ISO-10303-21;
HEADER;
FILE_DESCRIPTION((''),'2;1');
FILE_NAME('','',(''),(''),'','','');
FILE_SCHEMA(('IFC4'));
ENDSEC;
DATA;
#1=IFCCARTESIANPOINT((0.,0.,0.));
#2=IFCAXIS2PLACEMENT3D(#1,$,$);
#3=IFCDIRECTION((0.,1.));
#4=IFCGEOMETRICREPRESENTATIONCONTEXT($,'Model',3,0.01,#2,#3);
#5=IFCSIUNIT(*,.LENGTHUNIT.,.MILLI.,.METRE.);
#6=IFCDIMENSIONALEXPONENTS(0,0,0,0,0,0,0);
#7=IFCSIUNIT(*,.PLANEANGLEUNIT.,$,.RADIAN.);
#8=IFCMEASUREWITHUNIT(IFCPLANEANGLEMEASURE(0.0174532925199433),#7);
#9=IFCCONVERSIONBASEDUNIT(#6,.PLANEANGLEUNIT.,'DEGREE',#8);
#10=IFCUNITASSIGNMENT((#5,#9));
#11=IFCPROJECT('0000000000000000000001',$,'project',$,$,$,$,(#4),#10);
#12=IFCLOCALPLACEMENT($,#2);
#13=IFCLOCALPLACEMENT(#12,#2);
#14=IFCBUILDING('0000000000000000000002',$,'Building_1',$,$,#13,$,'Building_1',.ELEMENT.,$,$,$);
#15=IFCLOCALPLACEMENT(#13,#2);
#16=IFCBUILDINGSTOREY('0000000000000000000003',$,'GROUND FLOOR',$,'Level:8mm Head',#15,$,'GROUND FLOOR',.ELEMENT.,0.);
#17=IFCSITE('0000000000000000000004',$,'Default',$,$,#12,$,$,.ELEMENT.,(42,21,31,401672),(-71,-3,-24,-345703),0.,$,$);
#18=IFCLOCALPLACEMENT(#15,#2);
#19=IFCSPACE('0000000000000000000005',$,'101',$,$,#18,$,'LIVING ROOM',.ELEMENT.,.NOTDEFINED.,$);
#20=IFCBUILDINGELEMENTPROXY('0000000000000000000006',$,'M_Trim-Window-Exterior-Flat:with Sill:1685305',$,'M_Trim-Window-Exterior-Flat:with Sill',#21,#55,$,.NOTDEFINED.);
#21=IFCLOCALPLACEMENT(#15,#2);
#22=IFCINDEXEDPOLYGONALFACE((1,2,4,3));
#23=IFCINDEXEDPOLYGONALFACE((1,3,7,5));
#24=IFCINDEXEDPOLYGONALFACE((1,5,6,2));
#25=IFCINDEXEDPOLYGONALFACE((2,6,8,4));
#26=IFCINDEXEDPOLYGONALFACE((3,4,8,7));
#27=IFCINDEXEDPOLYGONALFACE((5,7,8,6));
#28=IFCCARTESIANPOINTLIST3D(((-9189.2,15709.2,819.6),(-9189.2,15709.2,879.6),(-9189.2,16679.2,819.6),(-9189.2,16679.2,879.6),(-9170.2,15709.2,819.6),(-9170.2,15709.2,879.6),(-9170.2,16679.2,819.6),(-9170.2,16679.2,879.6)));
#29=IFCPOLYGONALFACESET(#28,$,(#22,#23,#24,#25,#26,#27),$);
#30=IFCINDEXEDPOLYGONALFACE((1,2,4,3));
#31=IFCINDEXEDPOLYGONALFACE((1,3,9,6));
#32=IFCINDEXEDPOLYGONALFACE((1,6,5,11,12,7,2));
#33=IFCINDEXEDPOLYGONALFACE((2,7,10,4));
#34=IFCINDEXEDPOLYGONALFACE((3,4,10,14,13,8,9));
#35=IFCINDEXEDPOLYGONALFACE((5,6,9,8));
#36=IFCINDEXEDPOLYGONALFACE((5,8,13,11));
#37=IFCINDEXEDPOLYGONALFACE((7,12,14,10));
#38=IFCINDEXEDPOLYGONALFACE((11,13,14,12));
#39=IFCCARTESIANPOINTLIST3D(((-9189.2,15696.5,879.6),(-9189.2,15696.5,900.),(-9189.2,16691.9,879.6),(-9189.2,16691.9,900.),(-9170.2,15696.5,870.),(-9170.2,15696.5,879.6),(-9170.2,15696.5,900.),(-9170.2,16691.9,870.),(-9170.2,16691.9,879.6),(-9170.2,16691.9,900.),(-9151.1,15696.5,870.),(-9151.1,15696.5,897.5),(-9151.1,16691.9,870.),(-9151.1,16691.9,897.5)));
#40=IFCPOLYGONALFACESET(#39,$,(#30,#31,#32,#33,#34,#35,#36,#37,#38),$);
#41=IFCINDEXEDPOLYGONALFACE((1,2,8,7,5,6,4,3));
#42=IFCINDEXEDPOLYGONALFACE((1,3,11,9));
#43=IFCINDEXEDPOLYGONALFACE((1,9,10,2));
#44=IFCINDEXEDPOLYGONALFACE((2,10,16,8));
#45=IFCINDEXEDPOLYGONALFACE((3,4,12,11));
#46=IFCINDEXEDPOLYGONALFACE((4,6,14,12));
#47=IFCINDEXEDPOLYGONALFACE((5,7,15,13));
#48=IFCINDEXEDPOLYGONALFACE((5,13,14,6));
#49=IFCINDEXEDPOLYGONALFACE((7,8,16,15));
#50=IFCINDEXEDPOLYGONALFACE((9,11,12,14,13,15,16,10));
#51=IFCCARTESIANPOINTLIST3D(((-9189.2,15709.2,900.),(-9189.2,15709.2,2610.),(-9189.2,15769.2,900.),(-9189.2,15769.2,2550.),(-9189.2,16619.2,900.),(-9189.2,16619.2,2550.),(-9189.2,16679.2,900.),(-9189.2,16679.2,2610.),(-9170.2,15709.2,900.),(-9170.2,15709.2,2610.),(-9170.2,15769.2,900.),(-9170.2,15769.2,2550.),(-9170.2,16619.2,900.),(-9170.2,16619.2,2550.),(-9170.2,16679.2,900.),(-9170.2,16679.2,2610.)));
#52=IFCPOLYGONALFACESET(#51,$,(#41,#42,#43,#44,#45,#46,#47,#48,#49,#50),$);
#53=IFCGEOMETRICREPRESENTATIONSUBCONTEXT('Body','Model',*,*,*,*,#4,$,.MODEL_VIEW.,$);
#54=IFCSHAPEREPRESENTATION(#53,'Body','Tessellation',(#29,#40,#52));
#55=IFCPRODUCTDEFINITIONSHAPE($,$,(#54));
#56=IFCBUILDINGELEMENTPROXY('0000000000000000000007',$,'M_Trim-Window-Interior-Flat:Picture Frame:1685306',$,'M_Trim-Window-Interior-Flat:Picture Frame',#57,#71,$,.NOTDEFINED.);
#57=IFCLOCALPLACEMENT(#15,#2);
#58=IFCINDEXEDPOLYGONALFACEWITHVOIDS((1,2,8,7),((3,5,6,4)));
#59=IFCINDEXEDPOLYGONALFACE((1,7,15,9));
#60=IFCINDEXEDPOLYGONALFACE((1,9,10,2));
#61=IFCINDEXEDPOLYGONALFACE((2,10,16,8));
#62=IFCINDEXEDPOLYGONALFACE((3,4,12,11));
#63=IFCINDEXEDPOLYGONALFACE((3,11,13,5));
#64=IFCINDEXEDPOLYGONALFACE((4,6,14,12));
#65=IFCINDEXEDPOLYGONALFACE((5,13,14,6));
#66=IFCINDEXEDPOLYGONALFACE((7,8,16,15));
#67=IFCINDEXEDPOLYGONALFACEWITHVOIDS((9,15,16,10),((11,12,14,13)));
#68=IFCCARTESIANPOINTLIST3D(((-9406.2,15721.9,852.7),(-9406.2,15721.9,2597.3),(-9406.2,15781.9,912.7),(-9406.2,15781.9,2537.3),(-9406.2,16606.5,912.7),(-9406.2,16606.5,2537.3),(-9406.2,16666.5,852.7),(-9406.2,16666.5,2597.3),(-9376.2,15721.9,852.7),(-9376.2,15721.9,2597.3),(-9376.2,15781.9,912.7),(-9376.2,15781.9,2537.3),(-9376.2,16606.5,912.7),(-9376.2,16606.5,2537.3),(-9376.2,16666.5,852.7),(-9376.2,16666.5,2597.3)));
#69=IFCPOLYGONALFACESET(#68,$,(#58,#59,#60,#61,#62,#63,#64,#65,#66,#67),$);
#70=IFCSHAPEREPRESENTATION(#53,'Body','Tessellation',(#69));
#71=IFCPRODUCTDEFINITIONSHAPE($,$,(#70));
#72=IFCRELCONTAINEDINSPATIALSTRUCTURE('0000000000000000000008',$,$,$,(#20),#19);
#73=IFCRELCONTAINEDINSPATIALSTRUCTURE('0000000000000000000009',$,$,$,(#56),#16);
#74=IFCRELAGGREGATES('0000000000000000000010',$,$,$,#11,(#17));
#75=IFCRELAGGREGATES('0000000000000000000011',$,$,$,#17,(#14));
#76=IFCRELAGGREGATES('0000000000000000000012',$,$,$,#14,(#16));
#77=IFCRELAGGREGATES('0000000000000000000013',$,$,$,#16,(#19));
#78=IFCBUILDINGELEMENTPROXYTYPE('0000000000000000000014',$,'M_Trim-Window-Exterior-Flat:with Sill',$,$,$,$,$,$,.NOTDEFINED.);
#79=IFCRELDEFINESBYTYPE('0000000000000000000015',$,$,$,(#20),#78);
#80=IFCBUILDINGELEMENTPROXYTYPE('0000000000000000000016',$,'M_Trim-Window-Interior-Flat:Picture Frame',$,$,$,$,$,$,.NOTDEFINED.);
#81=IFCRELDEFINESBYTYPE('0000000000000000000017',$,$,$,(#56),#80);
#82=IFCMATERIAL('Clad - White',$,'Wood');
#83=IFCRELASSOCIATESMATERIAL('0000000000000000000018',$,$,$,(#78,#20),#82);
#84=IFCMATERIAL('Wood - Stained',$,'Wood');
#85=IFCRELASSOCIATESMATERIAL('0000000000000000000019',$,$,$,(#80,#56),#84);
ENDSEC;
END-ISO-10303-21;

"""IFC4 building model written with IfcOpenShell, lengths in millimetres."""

from ifc_helpers import new_model, entity, si_unit, converted_unit, direction, frame, origin, place, context, subcontext, project, spatial, indexed_curve, outline, extrude, source, transform, mapped, material, type_object, type_shapes, element, save


model = new_model("IFC4")

# Units and contexts
model_context = context("Model", 3, precision=0.01, world=origin(), true_north=direction((0.0, 1.0)))
body_context = subcontext(model_context, "Body", "Model", "MODEL_VIEW")
ifc_project = project(units=[si_unit("LENGTHUNIT", "METRE", prefix="MILLI"), converted_unit("PLANEANGLEUNIT", "DEGREE", entity("IfcPlaneAngleMeasure", 0.0174532925199433), si_unit("PLANEANGLEUNIT", "RADIAN"), dimensions=[0, 0, 0, 0, 0, 0, 0])], contexts=[model_context])

# Site, building, storey
site_placement = place(None, origin())
site = spatial("IfcSite", under=ifc_project, at=site_placement, Name="Default", CompositionType="ELEMENT", RefLatitude=(42, 21, 31, 401672), RefLongitude=(-71, -3, -24, -345703), RefElevation=0.0)
building_placement = place(site_placement, origin())
building = spatial("IfcBuilding", under=site, at=building_placement, Name="Building_1", LongName="Building_1", CompositionType="ELEMENT")
storey_placement = place(building_placement, origin())
storey = spatial("IfcBuildingStorey", under=building, at=storey_placement, Name="GROUND FLOOR", ObjectType="Level:8mm Head", LongName="GROUND FLOOR", CompositionType="ELEMENT", Elevation=0.0)

# Shared definitions
ifc_material_1 = material(Name="Wood - Stained", Category="Wood")

# Shared definitions
space_1_placement = place(storey_placement, origin())
space_1 = spatial("IfcSpace", under=storey, at=space_1_placement, Name="101", LongName="LIVING ROOM", CompositionType="ELEMENT", PredefinedType="NOTDEFINED")

# Building element proxies
ifc_material_2 = material(Name="Clad - White", Category="Wood")
building_element_proxy_type_1 = type_object("IfcBuildingElementProxyType", Name="M_Trim-Window-Exterior-Flat:with Sill", PredefinedType="NOTDEFINED", material=ifc_material_2)
shared_shape_1 = source(origin(), body_context, "Body", "SweptSolid", [
    extrude(outline(indexed_curve([(-485.0, -30.0), (485.0, -30.0), (485.0, 30.0), (-485.0, 30.0), (-485.0, -30.0)], self_intersect=False)), frame((0.0, -1700.4, 0.0), z_axis=(0.0, 0.0, 1.0), x_axis=(-1.0, 0.0, 0.0)), (0.0, 0.0, 1.0), 19.1),
    extrude(outline(indexed_curve([(-19.0, -15.2), (0.0, -15.2), (0.0, -5.7), (19.0, -5.7), (19.0, 14.8), (0.0, 14.8), (-19.0, 12.3), (-19.0, -15.2)], self_intersect=False)), frame((-497.7, -1664.8, 19.0), z_axis=(1.0, 0.0, 0.0), x_axis=(0.0, 0.0, -1.0)), (0.0, 0.0, 1.0), 995.4),
    extrude(outline(indexed_curve([(-870.0, -485.0), (840.0, -485.0), (840.0, -425.0), (-810.0, -425.0), (-810.0, 425.0), (840.0, 425.0), (840.0, 485.0), (-870.0, 485.0), (-870.0, -485.0)], self_intersect=False)), frame((0.0, -810.0, 0.0), z_axis=(0.0, 0.0, 1.0), x_axis=(0.0, -1.0, 0.0)), (0.0, 0.0, 1.0), 19.1),
])
type_shapes(building_element_proxy_type_1, [shared_shape_1])
proxy_1_placement = place(space_1_placement, frame((-9189.2, 16194.2, 2550.0), z_axis=(1.0, 0.0, 0.0), x_axis=(0.0, 1.0, 0.0)))
element("IfcBuildingElementProxy", 1, at=proxy_1_placement, inside=space_1, type_object=building_element_proxy_type_1, material=ifc_material_2, Name="M_Trim-Window-Exterior-Flat:with Sill:1685305", ObjectType="M_Trim-Window-Exterior-Flat:with Sill", PredefinedType="NOTDEFINED", context=body_context, shape_type="MappedRepresentation", body=[
    mapped(shared_shape_1, transform((0.0, 0.0, 0.0), scale=1.0)),
])
building_element_proxy_type_2 = type_object("IfcBuildingElementProxyType", Name="M_Trim-Window-Interior-Flat:Picture Frame", PredefinedType="NOTDEFINED", material=ifc_material_1)
shared_shape_2 = source(origin(), body_context, "Body", "SweptSolid", [
    extrude(outline(indexed_curve([(-472.3, -872.3), (472.3, -872.3), (472.3, 872.3), (-472.3, 872.3), (-472.3, -872.3)], self_intersect=False), holes=[indexed_curve([(-412.3, -812.3), (-412.3, 812.3), (412.3, 812.3), (412.3, -812.3), (-412.3, -812.3)], self_intersect=False)]), frame((0.0, -825.0, 0.0), z_axis=(0.0, 0.0, 1.0), x_axis=(-1.0, 0.0, 0.0)), (0.0, 0.0, 1.0), 30.0),
])
type_shapes(building_element_proxy_type_2, [shared_shape_2])
proxy_2_placement = place(storey_placement, frame((-9376.2, 16194.2, 2550.0), z_axis=(-1.0, 0.0, 0.0), x_axis=(0.0, -1.0, 0.0)))
element("IfcBuildingElementProxy", 2, at=proxy_2_placement, inside=storey, type_object=building_element_proxy_type_2, material=ifc_material_1, Name="M_Trim-Window-Interior-Flat:Picture Frame:1685306", ObjectType="M_Trim-Window-Interior-Flat:Picture Frame", PredefinedType="NOTDEFINED", context=body_context, shape_type="MappedRepresentation", body=[
    mapped(shared_shape_2, transform((0.0, 0.0, 0.0), scale=1.0)),
])

save(model, "model.ifc")
